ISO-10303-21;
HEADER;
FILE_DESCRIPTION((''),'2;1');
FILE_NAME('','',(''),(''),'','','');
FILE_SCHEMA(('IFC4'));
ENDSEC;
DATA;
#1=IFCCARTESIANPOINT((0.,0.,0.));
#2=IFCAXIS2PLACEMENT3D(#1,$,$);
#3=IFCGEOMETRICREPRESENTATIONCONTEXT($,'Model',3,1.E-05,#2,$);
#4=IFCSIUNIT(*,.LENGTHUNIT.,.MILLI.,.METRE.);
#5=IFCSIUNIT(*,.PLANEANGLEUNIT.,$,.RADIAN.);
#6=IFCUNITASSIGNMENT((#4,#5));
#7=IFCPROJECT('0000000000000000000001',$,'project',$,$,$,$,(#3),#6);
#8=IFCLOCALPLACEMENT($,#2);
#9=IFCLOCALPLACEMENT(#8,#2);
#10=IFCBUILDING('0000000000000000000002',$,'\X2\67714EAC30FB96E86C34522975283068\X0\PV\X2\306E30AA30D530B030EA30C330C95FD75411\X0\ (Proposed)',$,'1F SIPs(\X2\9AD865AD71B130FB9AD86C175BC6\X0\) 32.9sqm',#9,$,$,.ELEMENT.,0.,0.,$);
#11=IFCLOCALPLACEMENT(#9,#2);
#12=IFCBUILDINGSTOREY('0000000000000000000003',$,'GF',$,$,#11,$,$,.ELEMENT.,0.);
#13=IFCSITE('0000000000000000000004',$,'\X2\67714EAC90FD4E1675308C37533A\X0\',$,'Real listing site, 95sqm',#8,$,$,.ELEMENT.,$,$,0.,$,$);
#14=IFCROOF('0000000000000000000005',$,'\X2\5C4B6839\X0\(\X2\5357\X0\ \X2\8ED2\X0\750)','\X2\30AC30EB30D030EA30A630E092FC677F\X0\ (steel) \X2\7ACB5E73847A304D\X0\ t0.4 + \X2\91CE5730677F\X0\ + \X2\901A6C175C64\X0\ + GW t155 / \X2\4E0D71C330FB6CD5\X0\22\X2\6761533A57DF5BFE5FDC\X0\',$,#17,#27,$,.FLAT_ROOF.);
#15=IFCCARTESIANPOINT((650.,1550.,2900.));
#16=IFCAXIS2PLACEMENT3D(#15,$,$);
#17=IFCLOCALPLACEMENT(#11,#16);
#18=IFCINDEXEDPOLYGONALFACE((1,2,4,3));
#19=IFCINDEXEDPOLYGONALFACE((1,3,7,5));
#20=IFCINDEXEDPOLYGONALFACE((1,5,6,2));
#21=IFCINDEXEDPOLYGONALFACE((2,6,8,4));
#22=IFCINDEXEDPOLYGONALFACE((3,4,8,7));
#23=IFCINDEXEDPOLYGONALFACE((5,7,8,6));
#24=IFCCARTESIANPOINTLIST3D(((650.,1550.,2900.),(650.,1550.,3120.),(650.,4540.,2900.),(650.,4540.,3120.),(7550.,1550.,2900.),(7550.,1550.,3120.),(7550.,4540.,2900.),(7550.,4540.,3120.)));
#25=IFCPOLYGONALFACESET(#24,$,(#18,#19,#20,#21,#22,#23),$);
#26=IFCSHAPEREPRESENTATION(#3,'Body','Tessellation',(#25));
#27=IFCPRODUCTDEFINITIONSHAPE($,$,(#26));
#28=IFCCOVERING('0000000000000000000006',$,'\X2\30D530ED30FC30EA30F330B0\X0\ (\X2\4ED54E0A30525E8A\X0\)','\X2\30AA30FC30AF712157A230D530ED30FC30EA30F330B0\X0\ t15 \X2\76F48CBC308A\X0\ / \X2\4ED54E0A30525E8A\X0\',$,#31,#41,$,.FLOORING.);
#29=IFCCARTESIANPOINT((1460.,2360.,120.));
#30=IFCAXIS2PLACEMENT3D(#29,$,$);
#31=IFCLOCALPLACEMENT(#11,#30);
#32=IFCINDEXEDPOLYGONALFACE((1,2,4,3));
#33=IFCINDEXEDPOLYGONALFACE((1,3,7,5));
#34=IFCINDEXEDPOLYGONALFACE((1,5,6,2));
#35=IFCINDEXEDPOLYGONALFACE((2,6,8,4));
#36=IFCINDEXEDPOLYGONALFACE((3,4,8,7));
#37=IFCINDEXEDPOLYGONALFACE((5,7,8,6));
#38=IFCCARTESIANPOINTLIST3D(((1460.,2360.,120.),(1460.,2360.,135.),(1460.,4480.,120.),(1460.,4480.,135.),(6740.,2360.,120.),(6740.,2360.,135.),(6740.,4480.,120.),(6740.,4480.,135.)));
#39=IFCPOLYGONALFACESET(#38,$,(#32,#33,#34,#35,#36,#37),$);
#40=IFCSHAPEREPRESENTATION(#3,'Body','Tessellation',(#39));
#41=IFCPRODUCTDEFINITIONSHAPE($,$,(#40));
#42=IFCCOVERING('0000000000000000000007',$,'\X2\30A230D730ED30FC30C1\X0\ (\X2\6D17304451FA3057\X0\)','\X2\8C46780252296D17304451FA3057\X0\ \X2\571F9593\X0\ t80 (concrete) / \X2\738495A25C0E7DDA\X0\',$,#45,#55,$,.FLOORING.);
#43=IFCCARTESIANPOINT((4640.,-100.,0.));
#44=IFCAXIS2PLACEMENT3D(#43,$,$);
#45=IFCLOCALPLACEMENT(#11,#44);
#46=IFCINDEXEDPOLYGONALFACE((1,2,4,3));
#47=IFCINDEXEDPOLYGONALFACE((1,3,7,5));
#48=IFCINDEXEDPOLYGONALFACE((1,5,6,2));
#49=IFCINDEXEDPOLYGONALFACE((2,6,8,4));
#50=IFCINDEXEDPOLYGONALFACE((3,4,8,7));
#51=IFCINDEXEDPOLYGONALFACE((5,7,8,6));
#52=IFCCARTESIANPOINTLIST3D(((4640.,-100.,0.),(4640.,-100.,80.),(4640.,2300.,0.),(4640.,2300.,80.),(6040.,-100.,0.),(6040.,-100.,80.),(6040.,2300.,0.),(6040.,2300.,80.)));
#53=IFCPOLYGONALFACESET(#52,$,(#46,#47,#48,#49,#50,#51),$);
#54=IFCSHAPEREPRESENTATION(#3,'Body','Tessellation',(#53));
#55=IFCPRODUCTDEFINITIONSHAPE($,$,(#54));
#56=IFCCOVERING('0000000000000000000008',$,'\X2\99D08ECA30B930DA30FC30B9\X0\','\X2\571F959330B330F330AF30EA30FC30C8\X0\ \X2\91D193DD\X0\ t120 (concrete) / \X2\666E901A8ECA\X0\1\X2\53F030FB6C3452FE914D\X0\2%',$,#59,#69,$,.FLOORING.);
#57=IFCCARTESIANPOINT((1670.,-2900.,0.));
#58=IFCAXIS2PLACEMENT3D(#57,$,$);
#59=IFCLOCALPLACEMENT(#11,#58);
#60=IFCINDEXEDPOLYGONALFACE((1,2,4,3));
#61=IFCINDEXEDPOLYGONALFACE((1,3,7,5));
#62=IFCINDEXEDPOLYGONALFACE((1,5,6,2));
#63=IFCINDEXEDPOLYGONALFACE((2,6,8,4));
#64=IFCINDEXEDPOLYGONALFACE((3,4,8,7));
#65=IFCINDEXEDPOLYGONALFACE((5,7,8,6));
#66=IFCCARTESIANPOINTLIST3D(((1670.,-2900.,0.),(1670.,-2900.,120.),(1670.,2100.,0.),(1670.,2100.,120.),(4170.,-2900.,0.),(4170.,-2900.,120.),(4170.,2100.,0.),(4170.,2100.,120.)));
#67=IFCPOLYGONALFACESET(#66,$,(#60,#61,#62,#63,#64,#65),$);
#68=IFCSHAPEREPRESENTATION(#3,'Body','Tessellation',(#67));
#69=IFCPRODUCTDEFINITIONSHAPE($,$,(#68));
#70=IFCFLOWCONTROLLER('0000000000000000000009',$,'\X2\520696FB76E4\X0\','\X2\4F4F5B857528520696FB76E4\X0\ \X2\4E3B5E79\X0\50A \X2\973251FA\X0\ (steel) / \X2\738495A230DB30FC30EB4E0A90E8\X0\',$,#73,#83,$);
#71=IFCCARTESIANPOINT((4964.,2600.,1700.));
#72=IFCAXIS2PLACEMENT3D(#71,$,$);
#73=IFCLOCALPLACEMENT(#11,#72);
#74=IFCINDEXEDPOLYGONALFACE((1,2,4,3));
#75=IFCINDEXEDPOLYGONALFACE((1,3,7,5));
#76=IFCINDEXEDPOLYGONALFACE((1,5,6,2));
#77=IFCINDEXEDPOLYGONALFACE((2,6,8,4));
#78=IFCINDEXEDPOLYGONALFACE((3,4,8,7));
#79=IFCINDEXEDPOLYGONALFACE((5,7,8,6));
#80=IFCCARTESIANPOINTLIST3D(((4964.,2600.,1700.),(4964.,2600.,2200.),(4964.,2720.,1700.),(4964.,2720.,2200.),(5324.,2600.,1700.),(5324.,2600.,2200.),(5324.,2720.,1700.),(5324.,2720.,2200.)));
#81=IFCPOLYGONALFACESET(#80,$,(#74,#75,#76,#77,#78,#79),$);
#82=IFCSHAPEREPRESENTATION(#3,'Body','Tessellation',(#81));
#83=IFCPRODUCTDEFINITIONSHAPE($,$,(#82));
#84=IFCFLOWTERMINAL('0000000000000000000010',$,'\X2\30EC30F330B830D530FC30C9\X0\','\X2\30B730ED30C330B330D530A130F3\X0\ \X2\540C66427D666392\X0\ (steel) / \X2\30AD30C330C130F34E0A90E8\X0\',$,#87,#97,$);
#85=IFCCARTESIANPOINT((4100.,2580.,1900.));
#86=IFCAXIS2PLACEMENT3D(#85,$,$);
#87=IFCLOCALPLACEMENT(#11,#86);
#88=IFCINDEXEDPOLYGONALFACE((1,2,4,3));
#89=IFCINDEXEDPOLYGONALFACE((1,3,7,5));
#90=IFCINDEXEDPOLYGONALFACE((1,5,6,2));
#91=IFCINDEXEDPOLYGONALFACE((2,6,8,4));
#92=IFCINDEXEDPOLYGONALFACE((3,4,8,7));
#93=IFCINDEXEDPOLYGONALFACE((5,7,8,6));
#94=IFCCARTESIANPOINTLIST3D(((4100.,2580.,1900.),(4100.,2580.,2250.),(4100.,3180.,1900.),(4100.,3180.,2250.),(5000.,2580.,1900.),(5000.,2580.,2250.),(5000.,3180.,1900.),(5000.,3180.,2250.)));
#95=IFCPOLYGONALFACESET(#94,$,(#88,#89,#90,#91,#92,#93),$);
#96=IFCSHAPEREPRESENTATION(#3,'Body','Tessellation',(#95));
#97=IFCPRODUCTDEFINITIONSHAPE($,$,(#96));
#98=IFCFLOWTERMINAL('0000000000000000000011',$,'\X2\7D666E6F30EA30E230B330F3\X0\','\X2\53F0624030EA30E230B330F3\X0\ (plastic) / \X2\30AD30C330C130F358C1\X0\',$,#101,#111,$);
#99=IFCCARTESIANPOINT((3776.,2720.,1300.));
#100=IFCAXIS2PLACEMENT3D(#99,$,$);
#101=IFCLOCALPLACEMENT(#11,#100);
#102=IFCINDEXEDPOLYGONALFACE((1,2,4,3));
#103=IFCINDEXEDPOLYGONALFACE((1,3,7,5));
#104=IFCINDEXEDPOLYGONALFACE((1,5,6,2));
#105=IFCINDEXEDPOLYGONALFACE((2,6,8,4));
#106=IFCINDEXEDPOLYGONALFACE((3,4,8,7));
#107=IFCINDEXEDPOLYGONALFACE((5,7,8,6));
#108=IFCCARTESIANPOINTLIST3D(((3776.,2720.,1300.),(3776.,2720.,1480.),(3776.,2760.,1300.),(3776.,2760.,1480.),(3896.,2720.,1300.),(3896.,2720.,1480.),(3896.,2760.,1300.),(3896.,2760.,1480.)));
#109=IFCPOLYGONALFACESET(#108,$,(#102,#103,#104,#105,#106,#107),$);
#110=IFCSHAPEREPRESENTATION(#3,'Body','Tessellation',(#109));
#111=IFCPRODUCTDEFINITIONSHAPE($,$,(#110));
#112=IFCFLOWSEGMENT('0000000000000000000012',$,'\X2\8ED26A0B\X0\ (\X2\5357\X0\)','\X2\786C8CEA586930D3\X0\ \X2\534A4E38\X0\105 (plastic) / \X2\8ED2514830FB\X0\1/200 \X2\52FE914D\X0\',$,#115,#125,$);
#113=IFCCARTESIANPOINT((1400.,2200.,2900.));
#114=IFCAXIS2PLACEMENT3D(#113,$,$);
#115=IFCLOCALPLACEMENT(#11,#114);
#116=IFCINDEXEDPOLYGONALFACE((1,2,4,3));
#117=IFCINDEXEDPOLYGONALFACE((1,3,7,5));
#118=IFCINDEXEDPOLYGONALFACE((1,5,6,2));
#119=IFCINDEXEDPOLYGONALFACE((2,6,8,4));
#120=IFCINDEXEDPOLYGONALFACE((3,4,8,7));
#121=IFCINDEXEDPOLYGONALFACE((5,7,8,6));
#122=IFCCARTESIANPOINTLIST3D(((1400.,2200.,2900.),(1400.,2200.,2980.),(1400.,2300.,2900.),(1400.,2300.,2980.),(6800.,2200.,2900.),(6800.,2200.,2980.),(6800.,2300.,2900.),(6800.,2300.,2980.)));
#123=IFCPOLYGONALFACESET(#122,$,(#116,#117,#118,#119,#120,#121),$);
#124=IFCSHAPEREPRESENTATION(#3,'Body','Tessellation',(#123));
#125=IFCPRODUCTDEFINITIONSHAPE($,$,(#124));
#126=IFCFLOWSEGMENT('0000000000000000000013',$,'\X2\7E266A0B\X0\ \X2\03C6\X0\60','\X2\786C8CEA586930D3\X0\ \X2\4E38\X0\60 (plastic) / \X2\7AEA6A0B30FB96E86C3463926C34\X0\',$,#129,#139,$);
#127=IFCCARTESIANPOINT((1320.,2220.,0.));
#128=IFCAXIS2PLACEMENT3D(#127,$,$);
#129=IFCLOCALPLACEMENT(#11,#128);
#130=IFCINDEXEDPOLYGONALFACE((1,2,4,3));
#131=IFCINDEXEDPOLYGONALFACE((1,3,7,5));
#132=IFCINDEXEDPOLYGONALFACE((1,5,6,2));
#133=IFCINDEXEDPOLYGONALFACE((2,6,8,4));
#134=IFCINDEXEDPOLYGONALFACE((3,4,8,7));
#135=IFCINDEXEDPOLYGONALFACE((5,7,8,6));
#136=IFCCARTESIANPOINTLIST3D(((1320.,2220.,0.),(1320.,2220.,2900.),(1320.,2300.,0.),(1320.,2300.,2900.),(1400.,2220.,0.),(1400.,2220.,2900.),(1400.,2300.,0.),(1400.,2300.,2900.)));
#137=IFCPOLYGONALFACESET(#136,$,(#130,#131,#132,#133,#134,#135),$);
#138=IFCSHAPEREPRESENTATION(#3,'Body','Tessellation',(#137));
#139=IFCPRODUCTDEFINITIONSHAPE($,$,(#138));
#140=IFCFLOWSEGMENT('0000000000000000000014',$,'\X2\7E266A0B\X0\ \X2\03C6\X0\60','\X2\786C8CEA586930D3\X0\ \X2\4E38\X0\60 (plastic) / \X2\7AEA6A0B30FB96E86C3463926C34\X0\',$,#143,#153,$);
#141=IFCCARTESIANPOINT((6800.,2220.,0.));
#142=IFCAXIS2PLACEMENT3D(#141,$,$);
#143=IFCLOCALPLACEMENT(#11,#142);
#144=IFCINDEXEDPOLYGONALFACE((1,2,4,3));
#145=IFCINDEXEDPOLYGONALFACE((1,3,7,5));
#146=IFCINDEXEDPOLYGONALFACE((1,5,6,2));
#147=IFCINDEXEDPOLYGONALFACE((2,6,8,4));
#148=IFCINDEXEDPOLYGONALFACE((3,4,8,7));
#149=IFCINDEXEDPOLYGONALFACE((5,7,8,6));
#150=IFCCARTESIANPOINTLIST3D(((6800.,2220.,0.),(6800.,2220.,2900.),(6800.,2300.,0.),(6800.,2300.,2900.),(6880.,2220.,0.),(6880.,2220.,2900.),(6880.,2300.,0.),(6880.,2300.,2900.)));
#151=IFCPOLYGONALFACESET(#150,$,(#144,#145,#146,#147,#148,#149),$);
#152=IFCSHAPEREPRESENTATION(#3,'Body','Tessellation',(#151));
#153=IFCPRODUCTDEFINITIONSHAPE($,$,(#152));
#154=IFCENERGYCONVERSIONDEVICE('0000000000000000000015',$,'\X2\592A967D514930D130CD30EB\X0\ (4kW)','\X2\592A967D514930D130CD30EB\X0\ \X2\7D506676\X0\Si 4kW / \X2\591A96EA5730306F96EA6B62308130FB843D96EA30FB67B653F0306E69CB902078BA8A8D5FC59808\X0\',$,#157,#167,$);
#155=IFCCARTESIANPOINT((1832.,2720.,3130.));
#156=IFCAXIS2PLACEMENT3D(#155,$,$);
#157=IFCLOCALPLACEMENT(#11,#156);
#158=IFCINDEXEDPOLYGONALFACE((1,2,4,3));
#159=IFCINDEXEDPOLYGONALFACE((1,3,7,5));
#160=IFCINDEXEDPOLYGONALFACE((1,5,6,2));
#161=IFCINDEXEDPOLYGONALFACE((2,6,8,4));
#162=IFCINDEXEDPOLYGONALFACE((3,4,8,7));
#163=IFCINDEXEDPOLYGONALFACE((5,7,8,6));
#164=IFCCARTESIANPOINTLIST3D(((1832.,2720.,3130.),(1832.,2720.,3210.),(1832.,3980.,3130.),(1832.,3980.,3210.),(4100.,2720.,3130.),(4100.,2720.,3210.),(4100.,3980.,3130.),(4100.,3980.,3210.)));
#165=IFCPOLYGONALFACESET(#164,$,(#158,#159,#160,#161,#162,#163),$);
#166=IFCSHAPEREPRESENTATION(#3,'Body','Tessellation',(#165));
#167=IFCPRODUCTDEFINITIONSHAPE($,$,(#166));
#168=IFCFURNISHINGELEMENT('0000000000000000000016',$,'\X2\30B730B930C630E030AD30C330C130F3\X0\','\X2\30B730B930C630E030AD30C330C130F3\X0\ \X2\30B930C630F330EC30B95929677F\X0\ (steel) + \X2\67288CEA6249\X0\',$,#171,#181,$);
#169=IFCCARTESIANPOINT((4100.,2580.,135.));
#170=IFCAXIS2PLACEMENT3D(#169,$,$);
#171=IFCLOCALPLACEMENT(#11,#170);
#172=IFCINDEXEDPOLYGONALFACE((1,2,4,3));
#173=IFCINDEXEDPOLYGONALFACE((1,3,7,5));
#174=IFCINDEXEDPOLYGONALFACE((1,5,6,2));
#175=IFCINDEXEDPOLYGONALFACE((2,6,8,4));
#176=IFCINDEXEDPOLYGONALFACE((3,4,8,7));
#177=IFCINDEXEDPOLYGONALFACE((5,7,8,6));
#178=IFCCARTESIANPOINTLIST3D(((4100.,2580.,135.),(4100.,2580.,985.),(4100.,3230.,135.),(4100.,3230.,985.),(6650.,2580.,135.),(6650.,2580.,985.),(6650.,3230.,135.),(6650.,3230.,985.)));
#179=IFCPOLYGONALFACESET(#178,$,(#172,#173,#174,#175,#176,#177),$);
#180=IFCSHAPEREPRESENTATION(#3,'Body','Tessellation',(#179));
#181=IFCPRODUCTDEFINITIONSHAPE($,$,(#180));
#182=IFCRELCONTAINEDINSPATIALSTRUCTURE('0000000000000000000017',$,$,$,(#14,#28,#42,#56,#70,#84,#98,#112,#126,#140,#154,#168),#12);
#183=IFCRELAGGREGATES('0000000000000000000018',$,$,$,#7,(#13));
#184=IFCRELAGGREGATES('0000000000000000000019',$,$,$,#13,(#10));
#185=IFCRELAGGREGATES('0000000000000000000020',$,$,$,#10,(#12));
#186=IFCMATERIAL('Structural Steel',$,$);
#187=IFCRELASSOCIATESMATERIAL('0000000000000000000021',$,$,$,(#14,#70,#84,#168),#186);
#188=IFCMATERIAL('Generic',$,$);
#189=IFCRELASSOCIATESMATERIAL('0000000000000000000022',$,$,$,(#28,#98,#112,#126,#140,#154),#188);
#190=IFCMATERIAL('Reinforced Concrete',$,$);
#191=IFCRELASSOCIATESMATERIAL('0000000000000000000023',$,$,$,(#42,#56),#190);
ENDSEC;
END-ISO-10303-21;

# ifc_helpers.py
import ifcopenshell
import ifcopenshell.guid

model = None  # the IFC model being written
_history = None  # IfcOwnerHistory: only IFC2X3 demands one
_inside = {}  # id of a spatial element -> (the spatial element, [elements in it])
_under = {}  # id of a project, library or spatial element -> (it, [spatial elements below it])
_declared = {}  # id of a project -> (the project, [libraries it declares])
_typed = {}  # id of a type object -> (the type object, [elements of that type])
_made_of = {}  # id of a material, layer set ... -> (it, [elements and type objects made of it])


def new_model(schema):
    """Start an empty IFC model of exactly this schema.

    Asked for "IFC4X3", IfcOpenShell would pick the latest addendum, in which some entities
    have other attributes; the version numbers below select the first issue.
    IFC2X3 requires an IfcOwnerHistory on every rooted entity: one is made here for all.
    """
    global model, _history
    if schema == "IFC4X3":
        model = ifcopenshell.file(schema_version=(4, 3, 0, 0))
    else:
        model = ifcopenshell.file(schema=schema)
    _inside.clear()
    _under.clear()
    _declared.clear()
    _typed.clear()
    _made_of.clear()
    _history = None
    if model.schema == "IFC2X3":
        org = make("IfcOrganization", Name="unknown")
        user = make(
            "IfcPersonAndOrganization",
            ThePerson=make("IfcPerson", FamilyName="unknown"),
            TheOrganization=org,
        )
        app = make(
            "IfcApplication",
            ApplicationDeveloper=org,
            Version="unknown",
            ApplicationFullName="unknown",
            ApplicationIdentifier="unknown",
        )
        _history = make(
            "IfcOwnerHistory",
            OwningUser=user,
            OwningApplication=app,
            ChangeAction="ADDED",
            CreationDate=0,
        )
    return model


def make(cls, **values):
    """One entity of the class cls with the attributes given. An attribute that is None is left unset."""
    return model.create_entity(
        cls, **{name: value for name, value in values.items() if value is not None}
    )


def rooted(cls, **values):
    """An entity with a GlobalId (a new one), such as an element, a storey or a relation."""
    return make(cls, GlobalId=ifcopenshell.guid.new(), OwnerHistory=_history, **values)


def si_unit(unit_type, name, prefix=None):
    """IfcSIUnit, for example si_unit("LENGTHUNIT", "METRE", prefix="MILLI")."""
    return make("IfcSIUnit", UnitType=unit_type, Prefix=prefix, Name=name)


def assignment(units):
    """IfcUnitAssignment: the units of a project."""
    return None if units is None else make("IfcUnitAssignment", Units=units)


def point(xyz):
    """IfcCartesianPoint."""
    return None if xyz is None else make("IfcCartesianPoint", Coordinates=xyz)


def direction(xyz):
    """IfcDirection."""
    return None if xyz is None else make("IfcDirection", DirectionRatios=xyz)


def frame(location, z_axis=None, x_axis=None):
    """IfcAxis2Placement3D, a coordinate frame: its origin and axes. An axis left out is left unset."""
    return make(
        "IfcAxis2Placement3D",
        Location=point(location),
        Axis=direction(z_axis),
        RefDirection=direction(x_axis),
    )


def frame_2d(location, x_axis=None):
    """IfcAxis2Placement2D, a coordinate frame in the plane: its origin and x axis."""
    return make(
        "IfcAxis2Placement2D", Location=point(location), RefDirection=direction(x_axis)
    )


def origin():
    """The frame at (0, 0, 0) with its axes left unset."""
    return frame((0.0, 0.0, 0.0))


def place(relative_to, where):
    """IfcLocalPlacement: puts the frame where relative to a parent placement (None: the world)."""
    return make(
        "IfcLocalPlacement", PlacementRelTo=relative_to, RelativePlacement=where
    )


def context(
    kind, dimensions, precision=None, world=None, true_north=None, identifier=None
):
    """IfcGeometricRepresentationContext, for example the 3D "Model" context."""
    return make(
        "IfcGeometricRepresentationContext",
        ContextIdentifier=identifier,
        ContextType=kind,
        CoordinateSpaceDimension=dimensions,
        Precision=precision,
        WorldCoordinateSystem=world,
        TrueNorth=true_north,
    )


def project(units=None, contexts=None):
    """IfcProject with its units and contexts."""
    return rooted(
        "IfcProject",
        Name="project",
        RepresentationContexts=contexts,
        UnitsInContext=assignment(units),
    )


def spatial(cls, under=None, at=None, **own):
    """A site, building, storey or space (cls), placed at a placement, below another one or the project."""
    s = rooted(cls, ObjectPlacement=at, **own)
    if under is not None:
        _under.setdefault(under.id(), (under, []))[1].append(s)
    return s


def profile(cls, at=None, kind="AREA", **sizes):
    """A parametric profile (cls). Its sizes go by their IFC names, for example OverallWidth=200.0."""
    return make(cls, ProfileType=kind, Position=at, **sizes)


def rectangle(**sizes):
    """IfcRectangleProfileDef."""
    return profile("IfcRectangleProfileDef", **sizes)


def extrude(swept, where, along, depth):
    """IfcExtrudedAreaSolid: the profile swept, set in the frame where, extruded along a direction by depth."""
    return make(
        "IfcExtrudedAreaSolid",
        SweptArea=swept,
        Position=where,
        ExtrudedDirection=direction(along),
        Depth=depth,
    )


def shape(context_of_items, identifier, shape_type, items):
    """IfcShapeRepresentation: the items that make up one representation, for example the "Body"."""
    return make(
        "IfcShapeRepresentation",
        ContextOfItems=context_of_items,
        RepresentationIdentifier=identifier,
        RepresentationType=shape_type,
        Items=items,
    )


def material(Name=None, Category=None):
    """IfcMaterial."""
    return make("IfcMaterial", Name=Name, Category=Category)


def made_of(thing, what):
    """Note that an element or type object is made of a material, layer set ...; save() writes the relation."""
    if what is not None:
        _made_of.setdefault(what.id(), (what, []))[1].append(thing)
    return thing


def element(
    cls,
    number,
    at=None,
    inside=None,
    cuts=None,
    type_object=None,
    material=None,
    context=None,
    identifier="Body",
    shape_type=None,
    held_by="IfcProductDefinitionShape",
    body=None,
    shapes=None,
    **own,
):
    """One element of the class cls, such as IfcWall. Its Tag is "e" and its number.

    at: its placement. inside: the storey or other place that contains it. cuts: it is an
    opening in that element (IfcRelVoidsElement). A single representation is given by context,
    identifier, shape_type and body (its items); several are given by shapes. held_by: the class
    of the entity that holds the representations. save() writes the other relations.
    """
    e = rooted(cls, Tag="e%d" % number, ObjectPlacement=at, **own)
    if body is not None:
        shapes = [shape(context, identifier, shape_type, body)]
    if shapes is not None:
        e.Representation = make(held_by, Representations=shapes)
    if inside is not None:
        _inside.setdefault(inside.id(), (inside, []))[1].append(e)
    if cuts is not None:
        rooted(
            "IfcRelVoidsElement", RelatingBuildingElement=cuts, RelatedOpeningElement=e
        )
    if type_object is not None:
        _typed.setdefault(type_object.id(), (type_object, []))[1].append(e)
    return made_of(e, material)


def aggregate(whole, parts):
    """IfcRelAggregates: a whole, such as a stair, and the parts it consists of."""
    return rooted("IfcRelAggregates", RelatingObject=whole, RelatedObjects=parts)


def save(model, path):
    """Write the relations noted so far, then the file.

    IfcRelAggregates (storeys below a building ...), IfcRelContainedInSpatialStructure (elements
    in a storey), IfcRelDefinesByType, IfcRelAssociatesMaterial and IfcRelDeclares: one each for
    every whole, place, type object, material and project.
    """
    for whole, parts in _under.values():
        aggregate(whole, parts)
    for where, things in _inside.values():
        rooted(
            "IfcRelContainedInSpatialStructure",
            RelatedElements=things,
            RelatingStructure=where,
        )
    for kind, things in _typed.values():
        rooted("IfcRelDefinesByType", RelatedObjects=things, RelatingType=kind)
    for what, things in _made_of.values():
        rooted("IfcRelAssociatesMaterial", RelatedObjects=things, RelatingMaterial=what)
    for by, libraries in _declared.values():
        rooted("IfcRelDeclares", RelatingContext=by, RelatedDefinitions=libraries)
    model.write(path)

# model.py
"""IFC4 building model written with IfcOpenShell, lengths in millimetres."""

from ifc_helpers import new_model, si_unit, frame, frame_2d, origin, place, context, project, spatial, rectangle, extrude, material, element, save


model = new_model("IFC4")

# Units and contexts
model_context = context("Model", 3, precision=1e-05, world=origin())
ifc_project = project(units=[si_unit("LENGTHUNIT", "METRE", prefix="MILLI"), si_unit("PLANEANGLEUNIT", "RADIAN")], contexts=[model_context])

# Site, building, storey
site_placement = place(None, origin())
site = spatial("IfcSite", under=ifc_project, at=site_placement, Name="東京都世田谷区", ObjectType="Real listing site, 95sqm", CompositionType="ELEMENT", RefElevation=0.0)
building_placement = place(site_placement, origin())
building = spatial("IfcBuilding", under=site, at=building_placement, Name="東京・雨水利用とPVのオフグリッド志向 (Proposed)", ObjectType="1F SIPs(高断熱・高気密) 32.9sqm", CompositionType="ELEMENT", ElevationOfRefHeight=0.0, ElevationOfTerrain=0.0)
storey_placement = place(building_placement, origin())
storey = spatial("IfcBuildingStorey", under=building, at=storey_placement, Name="GF", CompositionType="ELEMENT", Elevation=0.0)

# Shared definitions
ifc_material_1 = material(Name="Reinforced Concrete")

# Roof
ifc_material_2 = material(Name="Structural Steel")
roof_placement = place(storey_placement, frame((650.0, 1550.0, 2900.0)))
element("IfcRoof", 1, at=roof_placement, inside=storey, material=ifc_material_2, Name="屋根(南 軒750)", Description="ガルバリウム鋼板 (steel) 立平葺き t0.4 + 野地板 + 通気層 + GW t155 / 不燃・法22条区域対応", PredefinedType="FLAT_ROOF", context=model_context, shape_type="SweptSolid", body=[
    extrude(rectangle(XDim=6900.0, YDim=2990.0, at=frame_2d((3450.0, 1495.0))), frame((650.0, 1550.0, 2900.0)), (0.0, 0.0, 1.0), 220.0),
])

# Coverings
ifc_material_3 = material(Name="Generic")
covering_1_placement = place(storey_placement, frame((1460.0, 2360.0, 120.0)))
element("IfcCovering", 2, at=covering_1_placement, inside=storey, material=ifc_material_3, Name="フローリング (仕上げ床)", Description="オーク無垢フローリング t15 直貼り / 仕上げ床", PredefinedType="FLOORING", context=model_context, shape_type="SweptSolid", body=[
    extrude(rectangle(XDim=5280.0, YDim=2120.0, at=frame_2d((2640.0, 1060.0))), frame((1460.0, 2360.0, 120.0)), (0.0, 0.0, 1.0), 15.0),
])
covering_2_placement = place(storey_placement, frame((4640.0, -100.0, 0.0)))
element("IfcCovering", 3, at=covering_2_placement, inside=storey, material=ifc_material_1, Name="アプローチ (洗い出し)", Description="豆砂利洗い出し 土間 t80 (concrete) / 玄関導線", PredefinedType="FLOORING", context=model_context, shape_type="SweptSolid", body=[
    extrude(rectangle(XDim=1400.0, YDim=2400.0, at=frame_2d((700.0, 1200.0))), frame((4640.0, -100.0, 0.0)), (0.0, 0.0, 1.0), 80.0),
])
covering_3_placement = place(storey_placement, frame((1670.0, -2900.0, 0.0)))
element("IfcCovering", 4, at=covering_3_placement, inside=storey, material=ifc_material_1, Name="駐車スペース", Description="土間コンクリート 金鏝 t120 (concrete) / 普通車1台・水勾配2%", PredefinedType="FLOORING", context=model_context, shape_type="SweptSolid", body=[
    extrude(rectangle(XDim=2500.0, YDim=5000.0, at=frame_2d((1250.0, 2500.0))), frame((1670.0, -2900.0, 0.0)), (0.0, 0.0, 1.0), 120.0),
])

# Flow controller
flow_controller_placement = place(storey_placement, frame((4964.0, 2600.0, 1700.0)))
element("IfcFlowController", 5, at=flow_controller_placement, inside=storey, material=ifc_material_2, Name="分電盤", Description="住宅用分電盤 主幹50A 露出 (steel) / 玄関ホール上部", context=model_context, shape_type="SweptSolid", body=[
    extrude(rectangle(XDim=360.0, YDim=120.0, at=frame_2d((180.0, 60.0))), frame((4964.0, 2600.0, 1700.0)), (0.0, 0.0, 1.0), 500.0),
])

# Flow terminals
flow_terminal_1_placement = place(storey_placement, frame((4100.0, 2580.0, 1900.0)))
element("IfcFlowTerminal", 6, at=flow_terminal_1_placement, inside=storey, material=ifc_material_2, Name="レンジフード", Description="シロッコファン 同時給排 (steel) / キッチン上部", context=model_context, shape_type="SweptSolid", body=[
    extrude(rectangle(XDim=900.0, YDim=600.0, at=frame_2d((450.0, 300.0))), frame((4100.0, 2580.0, 1900.0)), (0.0, 0.0, 1.0), 350.0),
])
flow_terminal_2_placement = place(storey_placement, frame((3776.0, 2720.0, 1300.0)))
element("IfcFlowTerminal", 7, at=flow_terminal_2_placement, inside=storey, material=ifc_material_3, Name="給湯リモコン", Description="台所リモコン (plastic) / キッチン壁", context=model_context, shape_type="SweptSolid", body=[
    extrude(rectangle(XDim=120.0, YDim=40.0, at=frame_2d((60.0, 20.0))), frame((3776.0, 2720.0, 1300.0)), (0.0, 0.0, 1.0), 180.0),
])

# Flow segments
flow_segment_1_placement = place(storey_placement, frame((1400.0, 2200.0, 2900.0)))
element("IfcFlowSegment", 8, at=flow_segment_1_placement, inside=storey, material=ifc_material_3, Name="軒樋 (南)", Description="硬質塩ビ 半丸105 (plastic) / 軒先・1/200 勾配", context=model_context, shape_type="SweptSolid", body=[
    extrude(rectangle(XDim=5400.0, YDim=100.0, at=frame_2d((2700.0, 50.0))), frame((1400.0, 2200.0, 2900.0)), (0.0, 0.0, 1.0), 80.0),
])
flow_segment_2_placement = place(storey_placement, frame((1320.0, 2220.0, 0.0)))
element("IfcFlowSegment", 9, at=flow_segment_2_placement, inside=storey, material=ifc_material_3, Name="縦樋 φ60", Description="硬質塩ビ 丸60 (plastic) / 竪樋・雨水排水", context=model_context, shape_type="SweptSolid", body=[
    extrude(rectangle(XDim=80.0, YDim=80.0, at=frame_2d((40.0, 40.0))), frame((1320.0, 2220.0, 0.0)), (0.0, 0.0, 1.0), 2900.0),
])
flow_segment_3_placement = place(storey_placement, frame((6800.0, 2220.0, 0.0)))
element("IfcFlowSegment", 10, at=flow_segment_3_placement, inside=storey, material=ifc_material_3, Name="縦樋 φ60", Description="硬質塩ビ 丸60 (plastic) / 竪樋・雨水排水", context=model_context, shape_type="SweptSolid", body=[
    extrude(rectangle(XDim=80.0, YDim=80.0, at=frame_2d((40.0, 40.0))), frame((6800.0, 2220.0, 0.0)), (0.0, 0.0, 1.0), 2900.0),
])

# Energy conversion device
energy_conversion_device_placement = place(storey_placement, frame((1832.0, 2720.0, 3130.0)))
element("IfcEnergyConversionDevice", 11, at=energy_conversion_device_placement, inside=storey, material=ifc_material_3, Name="太陽光パネル (4kW)", Description="太陽光パネル 結晶Si 4kW / 多雪地は雪止め・落雪・架台の構造確認必須", context=model_context, shape_type="SweptSolid", body=[
    extrude(rectangle(XDim=2268.0, YDim=1260.0, at=frame_2d((1134.0, 630.0))), frame((1832.0, 2720.0, 3130.0)), (0.0, 0.0, 1.0), 80.0),
])

# Furnishing element
furnishing_placement = place(storey_placement, frame((4100.0, 2580.0, 135.0)))
element("IfcFurnishingElement", 12, at=furnishing_placement, inside=storey, material=ifc_material_2, Name="システムキッチン", Description="システムキッチン ステンレス天板 (steel) + 木質扉", context=model_context, shape_type="SweptSolid", body=[
    extrude(rectangle(XDim=2550.0, YDim=650.0, at=frame_2d((1275.0, 325.0))), frame((4100.0, 2580.0, 135.0)), (0.0, 0.0, 1.0), 850.0),
])

save(model, "model.ifc")
